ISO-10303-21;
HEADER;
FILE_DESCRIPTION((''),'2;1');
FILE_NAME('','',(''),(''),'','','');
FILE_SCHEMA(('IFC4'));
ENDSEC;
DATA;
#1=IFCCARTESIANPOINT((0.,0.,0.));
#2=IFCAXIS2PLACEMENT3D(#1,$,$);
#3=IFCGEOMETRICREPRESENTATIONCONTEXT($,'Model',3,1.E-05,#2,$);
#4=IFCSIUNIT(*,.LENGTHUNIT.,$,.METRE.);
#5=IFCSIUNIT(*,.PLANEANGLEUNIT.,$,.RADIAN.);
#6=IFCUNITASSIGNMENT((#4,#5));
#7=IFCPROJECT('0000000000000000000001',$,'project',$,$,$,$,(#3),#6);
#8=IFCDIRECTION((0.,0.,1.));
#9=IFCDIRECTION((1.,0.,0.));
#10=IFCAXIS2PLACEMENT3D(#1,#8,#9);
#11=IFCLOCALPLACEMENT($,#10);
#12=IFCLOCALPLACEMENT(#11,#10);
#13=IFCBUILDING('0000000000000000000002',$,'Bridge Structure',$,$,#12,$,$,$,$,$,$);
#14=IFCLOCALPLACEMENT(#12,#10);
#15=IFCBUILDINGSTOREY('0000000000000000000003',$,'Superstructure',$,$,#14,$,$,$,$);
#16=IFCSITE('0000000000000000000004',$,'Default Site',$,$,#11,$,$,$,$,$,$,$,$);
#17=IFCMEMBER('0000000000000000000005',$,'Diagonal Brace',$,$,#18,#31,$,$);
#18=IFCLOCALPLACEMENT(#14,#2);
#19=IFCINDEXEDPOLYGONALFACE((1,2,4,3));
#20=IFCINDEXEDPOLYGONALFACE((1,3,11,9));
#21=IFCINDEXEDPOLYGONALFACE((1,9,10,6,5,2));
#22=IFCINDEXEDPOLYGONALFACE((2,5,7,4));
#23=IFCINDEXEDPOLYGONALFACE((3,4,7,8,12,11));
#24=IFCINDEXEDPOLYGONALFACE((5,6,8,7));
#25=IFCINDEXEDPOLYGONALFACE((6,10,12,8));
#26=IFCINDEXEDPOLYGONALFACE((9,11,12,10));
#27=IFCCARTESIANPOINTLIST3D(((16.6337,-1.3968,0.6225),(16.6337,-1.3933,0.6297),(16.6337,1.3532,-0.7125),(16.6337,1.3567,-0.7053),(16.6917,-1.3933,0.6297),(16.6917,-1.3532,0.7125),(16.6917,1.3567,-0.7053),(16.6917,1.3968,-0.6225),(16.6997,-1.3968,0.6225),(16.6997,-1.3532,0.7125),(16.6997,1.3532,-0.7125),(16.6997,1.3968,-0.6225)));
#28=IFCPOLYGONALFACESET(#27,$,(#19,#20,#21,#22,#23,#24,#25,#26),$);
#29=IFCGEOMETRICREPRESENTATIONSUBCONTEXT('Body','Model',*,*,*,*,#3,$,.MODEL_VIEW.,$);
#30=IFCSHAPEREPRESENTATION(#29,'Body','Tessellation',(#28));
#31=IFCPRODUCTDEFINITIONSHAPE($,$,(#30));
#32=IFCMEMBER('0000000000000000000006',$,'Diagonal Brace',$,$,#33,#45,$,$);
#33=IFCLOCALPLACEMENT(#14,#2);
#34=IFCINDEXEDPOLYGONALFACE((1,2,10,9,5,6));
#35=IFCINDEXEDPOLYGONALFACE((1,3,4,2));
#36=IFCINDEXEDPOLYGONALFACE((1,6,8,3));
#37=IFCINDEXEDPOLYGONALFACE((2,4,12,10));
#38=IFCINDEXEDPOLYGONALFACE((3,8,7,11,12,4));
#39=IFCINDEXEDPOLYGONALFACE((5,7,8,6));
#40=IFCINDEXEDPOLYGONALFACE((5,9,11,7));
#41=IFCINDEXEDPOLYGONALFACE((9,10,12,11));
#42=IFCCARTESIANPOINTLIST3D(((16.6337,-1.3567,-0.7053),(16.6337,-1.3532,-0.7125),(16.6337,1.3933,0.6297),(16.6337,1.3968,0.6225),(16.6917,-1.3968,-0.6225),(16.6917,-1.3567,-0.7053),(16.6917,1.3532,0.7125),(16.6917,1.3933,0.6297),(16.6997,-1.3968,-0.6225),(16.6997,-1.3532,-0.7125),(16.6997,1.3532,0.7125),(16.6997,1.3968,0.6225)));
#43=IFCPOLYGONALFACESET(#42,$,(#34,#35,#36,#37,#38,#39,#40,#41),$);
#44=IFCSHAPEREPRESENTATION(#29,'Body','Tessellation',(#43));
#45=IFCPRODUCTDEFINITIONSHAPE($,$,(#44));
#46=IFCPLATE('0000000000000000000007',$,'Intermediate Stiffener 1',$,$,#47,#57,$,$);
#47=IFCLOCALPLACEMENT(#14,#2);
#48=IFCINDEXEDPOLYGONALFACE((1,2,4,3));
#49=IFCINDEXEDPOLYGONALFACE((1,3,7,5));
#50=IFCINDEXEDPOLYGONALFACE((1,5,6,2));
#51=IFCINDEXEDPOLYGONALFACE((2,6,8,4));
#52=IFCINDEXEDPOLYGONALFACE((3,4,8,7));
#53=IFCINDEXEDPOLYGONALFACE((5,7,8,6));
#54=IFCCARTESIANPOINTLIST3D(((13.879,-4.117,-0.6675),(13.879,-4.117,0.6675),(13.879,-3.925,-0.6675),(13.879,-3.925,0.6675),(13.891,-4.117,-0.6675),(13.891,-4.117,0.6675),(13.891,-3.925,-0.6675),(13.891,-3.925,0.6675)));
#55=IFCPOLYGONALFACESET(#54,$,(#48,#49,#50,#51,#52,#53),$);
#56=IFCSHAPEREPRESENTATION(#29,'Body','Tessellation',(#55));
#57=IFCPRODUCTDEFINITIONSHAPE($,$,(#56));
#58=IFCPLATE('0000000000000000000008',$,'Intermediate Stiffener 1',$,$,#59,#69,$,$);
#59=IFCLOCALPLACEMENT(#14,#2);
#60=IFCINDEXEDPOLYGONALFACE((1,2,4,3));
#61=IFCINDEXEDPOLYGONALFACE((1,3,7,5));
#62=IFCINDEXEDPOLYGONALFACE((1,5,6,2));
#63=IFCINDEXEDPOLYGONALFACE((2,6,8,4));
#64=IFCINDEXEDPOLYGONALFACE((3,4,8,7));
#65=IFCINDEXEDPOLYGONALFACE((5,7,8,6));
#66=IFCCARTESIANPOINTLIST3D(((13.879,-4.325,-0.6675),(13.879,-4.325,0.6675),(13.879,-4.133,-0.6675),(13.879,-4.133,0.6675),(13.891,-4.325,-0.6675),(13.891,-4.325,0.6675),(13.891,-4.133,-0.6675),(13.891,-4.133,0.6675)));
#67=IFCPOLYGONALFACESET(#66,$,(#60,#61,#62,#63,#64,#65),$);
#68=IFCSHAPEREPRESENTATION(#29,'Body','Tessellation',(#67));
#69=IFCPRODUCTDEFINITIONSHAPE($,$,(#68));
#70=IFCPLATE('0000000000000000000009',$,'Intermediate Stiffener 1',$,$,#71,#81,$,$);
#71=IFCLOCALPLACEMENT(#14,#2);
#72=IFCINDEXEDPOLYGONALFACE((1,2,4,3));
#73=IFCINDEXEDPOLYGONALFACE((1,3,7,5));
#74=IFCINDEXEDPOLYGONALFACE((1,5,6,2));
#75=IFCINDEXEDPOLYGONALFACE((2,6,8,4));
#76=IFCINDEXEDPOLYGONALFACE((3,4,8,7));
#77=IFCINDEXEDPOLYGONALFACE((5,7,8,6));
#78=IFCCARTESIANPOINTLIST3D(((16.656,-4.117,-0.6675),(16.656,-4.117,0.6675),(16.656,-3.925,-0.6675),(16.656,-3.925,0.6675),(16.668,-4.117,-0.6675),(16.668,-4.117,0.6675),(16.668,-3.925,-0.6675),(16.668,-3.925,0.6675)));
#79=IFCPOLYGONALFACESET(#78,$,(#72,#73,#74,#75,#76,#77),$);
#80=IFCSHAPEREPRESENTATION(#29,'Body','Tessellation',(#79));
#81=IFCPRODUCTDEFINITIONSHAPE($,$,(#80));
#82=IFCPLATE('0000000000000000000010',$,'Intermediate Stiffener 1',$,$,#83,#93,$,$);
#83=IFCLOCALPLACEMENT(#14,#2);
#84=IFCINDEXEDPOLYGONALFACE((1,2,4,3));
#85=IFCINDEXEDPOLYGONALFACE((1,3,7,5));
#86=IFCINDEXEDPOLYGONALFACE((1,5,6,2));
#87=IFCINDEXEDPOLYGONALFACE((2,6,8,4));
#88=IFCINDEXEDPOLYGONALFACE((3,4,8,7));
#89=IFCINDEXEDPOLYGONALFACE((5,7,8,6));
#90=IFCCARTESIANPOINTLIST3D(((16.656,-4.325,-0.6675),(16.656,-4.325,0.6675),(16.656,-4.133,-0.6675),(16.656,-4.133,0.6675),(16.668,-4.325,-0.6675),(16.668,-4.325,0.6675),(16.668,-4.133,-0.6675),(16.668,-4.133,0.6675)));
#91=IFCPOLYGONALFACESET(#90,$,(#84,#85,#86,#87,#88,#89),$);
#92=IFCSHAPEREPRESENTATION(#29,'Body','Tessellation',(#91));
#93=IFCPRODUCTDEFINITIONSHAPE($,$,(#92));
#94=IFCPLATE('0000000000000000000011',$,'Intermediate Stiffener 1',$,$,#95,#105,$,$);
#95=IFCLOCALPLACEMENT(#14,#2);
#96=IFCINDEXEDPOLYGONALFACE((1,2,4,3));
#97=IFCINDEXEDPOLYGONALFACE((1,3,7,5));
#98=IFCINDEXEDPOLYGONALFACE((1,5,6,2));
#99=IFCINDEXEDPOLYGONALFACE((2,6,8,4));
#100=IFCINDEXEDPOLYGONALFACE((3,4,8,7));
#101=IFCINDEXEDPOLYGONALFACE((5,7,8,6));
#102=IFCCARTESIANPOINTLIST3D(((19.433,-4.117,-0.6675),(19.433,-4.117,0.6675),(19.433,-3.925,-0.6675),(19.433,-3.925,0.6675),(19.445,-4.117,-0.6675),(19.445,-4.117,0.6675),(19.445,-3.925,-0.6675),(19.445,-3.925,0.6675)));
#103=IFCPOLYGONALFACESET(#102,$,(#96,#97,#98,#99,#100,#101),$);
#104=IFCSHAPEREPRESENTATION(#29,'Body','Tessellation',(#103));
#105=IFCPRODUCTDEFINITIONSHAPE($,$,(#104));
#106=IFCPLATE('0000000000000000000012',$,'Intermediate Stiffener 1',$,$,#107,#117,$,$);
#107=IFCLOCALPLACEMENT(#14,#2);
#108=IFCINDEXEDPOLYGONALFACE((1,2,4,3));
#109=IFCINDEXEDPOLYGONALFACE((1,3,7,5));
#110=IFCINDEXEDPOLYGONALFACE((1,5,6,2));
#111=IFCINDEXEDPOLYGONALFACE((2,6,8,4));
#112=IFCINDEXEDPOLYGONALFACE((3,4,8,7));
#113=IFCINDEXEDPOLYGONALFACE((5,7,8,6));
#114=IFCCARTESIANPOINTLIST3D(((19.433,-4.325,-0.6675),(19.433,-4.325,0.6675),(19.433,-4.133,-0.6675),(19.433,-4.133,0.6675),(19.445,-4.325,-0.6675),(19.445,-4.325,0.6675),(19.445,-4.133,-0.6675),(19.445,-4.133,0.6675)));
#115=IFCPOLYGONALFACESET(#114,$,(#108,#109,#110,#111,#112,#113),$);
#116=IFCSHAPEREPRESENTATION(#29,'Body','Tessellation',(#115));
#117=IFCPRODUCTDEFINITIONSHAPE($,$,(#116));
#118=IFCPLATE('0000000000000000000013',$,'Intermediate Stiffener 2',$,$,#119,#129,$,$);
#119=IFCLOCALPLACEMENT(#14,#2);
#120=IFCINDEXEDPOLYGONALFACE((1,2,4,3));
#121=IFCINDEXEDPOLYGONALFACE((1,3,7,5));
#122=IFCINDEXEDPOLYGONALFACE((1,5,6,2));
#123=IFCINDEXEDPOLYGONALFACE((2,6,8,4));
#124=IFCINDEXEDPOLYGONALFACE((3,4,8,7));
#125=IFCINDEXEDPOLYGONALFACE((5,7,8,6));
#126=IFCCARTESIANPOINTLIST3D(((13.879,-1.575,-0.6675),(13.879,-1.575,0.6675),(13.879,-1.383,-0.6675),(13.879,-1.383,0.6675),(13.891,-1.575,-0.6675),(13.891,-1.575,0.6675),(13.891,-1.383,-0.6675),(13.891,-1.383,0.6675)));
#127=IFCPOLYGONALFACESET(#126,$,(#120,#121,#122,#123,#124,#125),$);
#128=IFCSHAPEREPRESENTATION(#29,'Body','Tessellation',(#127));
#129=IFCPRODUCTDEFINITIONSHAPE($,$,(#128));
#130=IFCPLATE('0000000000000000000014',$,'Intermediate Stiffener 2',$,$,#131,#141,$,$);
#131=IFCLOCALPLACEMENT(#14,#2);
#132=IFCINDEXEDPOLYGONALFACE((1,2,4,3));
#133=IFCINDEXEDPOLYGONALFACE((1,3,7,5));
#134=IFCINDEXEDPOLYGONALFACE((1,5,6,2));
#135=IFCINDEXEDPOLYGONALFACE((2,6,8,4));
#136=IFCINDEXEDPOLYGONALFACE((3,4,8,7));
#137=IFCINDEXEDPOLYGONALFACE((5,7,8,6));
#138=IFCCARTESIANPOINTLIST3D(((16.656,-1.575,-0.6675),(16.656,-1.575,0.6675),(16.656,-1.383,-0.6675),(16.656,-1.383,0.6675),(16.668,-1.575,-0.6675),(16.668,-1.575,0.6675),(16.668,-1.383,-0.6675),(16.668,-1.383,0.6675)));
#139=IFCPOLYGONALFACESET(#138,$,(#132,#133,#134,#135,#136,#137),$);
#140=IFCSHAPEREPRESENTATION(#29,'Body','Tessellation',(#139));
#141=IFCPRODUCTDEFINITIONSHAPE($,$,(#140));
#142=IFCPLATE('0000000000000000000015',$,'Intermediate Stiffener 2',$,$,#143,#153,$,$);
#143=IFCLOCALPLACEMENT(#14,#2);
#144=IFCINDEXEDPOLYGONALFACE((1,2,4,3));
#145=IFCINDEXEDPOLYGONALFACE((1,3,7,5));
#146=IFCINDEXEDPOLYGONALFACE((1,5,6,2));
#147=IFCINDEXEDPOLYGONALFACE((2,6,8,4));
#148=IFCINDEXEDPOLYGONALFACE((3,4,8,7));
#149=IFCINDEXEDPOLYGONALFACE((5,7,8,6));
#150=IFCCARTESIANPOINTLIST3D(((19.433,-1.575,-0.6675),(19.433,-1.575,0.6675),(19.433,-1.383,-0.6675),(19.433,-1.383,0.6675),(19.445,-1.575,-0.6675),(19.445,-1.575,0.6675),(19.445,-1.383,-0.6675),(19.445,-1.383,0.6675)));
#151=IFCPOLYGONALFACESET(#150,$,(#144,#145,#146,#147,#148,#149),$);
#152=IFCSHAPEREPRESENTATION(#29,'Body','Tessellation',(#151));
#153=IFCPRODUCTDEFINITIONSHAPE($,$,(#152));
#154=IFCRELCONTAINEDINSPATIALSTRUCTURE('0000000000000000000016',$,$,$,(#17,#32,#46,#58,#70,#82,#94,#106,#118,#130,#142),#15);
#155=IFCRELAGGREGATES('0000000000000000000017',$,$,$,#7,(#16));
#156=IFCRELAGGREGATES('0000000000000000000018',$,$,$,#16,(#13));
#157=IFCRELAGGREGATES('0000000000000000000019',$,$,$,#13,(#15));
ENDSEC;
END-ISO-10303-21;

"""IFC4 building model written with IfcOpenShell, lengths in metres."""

from ifc_helpers import new_model, si_unit, frame, origin, origin_with_axes, origin_2d_with_axis, place, context, subcontext, project, spatial, rectangle, l_section, extrude, element, save


model = new_model("IFC4")

# Units and contexts
model_context = context("Model", 3, precision=1e-05, world=origin())
body_context = subcontext(model_context, "Body", "Model", "MODEL_VIEW")
ifc_project = project(units=[si_unit("LENGTHUNIT", "METRE"), si_unit("PLANEANGLEUNIT", "RADIAN")], contexts=[model_context])

# Site, building, storey
site_placement = place(None, origin_with_axes())
site = spatial("IfcSite", under=ifc_project, at=site_placement, Name="Default Site")
building_placement = place(site_placement, origin_with_axes())
building = spatial("IfcBuilding", under=site, at=building_placement, Name="Bridge Structure")
storey_placement = place(building_placement, origin_with_axes())
storey = spatial("IfcBuildingStorey", under=building, at=storey_placement, Name="Superstructure")

# Members
for number, where, z_axis, x_axis, name in (
    (1, (16.6667, -1.375, 0.6675), (0.0, 0.8996, -0.436715), (-1.0, 0.0, 0.0), "Diagonal Brace"),
    (2, (16.6667, -1.375, -0.6675), (0.0, 0.8996, 0.436715), (-1.0, 0.0, 0.0), "Diagonal Brace"),
):
    element("IfcMember", number, at=place(storey_placement, frame(where, z_axis=z_axis, x_axis=x_axis)), inside=storey, Name=name, context=body_context, shape_type="SweptSolid", body=[
        extrude(l_section(Depth=0.1, Width=0.066, Thickness=0.008, at=origin_2d_with_axis()), origin_with_axes(), (0.0, 0.0, 1.0), 3.0569),
    ])

# Plates
for number, where, z_axis, x_axis, name in (
    (3, (13.885, -4.021, -0.6675), (0.0, 0.0, 1.0), (1.0, 0.0, 0.0), "Intermediate Stiffener 1"),
    (4, (13.885, -4.229, -0.6675), (0.0, 0.0, 1.0), (1.0, 0.0, 0.0), "Intermediate Stiffener 1"),
    (5, (16.662, -4.021, -0.6675), (0.0, 0.0, 1.0), (1.0, 0.0, 0.0), "Intermediate Stiffener 1"),
    (6, (16.662, -4.229, -0.6675), (0.0, 0.0, 1.0), (1.0, 0.0, 0.0), "Intermediate Stiffener 1"),
    (7, (19.439, -4.021, -0.6675), (0.0, 0.0, 1.0), (1.0, 0.0, 0.0), "Intermediate Stiffener 1"),
    (8, (19.439, -4.229, -0.6675), (0.0, 0.0, 1.0), (1.0, 0.0, 0.0), "Intermediate Stiffener 1"),
    (9, (13.885, -1.479, -0.6675), (0.0, 0.0, 1.0), (1.0, 0.0, 0.0), "Intermediate Stiffener 2"),
    (10, (16.662, -1.479, -0.6675), (0.0, 0.0, 1.0), (1.0, 0.0, 0.0), "Intermediate Stiffener 2"),
    (11, (19.439, -1.479, -0.6675), (0.0, 0.0, 1.0), (1.0, 0.0, 0.0), "Intermediate Stiffener 2"),
):
    element("IfcPlate", number, at=place(storey_placement, frame(where, z_axis=z_axis, x_axis=x_axis)), inside=storey, Name=name, context=body_context, shape_type="SweptSolid", body=[
        extrude(rectangle(XDim=0.012, YDim=0.192, at=origin_2d_with_axis()), origin_with_axes(), (0.0, 0.0, 1.0), 1.335),
    ])

save(model, "model.ifc")
